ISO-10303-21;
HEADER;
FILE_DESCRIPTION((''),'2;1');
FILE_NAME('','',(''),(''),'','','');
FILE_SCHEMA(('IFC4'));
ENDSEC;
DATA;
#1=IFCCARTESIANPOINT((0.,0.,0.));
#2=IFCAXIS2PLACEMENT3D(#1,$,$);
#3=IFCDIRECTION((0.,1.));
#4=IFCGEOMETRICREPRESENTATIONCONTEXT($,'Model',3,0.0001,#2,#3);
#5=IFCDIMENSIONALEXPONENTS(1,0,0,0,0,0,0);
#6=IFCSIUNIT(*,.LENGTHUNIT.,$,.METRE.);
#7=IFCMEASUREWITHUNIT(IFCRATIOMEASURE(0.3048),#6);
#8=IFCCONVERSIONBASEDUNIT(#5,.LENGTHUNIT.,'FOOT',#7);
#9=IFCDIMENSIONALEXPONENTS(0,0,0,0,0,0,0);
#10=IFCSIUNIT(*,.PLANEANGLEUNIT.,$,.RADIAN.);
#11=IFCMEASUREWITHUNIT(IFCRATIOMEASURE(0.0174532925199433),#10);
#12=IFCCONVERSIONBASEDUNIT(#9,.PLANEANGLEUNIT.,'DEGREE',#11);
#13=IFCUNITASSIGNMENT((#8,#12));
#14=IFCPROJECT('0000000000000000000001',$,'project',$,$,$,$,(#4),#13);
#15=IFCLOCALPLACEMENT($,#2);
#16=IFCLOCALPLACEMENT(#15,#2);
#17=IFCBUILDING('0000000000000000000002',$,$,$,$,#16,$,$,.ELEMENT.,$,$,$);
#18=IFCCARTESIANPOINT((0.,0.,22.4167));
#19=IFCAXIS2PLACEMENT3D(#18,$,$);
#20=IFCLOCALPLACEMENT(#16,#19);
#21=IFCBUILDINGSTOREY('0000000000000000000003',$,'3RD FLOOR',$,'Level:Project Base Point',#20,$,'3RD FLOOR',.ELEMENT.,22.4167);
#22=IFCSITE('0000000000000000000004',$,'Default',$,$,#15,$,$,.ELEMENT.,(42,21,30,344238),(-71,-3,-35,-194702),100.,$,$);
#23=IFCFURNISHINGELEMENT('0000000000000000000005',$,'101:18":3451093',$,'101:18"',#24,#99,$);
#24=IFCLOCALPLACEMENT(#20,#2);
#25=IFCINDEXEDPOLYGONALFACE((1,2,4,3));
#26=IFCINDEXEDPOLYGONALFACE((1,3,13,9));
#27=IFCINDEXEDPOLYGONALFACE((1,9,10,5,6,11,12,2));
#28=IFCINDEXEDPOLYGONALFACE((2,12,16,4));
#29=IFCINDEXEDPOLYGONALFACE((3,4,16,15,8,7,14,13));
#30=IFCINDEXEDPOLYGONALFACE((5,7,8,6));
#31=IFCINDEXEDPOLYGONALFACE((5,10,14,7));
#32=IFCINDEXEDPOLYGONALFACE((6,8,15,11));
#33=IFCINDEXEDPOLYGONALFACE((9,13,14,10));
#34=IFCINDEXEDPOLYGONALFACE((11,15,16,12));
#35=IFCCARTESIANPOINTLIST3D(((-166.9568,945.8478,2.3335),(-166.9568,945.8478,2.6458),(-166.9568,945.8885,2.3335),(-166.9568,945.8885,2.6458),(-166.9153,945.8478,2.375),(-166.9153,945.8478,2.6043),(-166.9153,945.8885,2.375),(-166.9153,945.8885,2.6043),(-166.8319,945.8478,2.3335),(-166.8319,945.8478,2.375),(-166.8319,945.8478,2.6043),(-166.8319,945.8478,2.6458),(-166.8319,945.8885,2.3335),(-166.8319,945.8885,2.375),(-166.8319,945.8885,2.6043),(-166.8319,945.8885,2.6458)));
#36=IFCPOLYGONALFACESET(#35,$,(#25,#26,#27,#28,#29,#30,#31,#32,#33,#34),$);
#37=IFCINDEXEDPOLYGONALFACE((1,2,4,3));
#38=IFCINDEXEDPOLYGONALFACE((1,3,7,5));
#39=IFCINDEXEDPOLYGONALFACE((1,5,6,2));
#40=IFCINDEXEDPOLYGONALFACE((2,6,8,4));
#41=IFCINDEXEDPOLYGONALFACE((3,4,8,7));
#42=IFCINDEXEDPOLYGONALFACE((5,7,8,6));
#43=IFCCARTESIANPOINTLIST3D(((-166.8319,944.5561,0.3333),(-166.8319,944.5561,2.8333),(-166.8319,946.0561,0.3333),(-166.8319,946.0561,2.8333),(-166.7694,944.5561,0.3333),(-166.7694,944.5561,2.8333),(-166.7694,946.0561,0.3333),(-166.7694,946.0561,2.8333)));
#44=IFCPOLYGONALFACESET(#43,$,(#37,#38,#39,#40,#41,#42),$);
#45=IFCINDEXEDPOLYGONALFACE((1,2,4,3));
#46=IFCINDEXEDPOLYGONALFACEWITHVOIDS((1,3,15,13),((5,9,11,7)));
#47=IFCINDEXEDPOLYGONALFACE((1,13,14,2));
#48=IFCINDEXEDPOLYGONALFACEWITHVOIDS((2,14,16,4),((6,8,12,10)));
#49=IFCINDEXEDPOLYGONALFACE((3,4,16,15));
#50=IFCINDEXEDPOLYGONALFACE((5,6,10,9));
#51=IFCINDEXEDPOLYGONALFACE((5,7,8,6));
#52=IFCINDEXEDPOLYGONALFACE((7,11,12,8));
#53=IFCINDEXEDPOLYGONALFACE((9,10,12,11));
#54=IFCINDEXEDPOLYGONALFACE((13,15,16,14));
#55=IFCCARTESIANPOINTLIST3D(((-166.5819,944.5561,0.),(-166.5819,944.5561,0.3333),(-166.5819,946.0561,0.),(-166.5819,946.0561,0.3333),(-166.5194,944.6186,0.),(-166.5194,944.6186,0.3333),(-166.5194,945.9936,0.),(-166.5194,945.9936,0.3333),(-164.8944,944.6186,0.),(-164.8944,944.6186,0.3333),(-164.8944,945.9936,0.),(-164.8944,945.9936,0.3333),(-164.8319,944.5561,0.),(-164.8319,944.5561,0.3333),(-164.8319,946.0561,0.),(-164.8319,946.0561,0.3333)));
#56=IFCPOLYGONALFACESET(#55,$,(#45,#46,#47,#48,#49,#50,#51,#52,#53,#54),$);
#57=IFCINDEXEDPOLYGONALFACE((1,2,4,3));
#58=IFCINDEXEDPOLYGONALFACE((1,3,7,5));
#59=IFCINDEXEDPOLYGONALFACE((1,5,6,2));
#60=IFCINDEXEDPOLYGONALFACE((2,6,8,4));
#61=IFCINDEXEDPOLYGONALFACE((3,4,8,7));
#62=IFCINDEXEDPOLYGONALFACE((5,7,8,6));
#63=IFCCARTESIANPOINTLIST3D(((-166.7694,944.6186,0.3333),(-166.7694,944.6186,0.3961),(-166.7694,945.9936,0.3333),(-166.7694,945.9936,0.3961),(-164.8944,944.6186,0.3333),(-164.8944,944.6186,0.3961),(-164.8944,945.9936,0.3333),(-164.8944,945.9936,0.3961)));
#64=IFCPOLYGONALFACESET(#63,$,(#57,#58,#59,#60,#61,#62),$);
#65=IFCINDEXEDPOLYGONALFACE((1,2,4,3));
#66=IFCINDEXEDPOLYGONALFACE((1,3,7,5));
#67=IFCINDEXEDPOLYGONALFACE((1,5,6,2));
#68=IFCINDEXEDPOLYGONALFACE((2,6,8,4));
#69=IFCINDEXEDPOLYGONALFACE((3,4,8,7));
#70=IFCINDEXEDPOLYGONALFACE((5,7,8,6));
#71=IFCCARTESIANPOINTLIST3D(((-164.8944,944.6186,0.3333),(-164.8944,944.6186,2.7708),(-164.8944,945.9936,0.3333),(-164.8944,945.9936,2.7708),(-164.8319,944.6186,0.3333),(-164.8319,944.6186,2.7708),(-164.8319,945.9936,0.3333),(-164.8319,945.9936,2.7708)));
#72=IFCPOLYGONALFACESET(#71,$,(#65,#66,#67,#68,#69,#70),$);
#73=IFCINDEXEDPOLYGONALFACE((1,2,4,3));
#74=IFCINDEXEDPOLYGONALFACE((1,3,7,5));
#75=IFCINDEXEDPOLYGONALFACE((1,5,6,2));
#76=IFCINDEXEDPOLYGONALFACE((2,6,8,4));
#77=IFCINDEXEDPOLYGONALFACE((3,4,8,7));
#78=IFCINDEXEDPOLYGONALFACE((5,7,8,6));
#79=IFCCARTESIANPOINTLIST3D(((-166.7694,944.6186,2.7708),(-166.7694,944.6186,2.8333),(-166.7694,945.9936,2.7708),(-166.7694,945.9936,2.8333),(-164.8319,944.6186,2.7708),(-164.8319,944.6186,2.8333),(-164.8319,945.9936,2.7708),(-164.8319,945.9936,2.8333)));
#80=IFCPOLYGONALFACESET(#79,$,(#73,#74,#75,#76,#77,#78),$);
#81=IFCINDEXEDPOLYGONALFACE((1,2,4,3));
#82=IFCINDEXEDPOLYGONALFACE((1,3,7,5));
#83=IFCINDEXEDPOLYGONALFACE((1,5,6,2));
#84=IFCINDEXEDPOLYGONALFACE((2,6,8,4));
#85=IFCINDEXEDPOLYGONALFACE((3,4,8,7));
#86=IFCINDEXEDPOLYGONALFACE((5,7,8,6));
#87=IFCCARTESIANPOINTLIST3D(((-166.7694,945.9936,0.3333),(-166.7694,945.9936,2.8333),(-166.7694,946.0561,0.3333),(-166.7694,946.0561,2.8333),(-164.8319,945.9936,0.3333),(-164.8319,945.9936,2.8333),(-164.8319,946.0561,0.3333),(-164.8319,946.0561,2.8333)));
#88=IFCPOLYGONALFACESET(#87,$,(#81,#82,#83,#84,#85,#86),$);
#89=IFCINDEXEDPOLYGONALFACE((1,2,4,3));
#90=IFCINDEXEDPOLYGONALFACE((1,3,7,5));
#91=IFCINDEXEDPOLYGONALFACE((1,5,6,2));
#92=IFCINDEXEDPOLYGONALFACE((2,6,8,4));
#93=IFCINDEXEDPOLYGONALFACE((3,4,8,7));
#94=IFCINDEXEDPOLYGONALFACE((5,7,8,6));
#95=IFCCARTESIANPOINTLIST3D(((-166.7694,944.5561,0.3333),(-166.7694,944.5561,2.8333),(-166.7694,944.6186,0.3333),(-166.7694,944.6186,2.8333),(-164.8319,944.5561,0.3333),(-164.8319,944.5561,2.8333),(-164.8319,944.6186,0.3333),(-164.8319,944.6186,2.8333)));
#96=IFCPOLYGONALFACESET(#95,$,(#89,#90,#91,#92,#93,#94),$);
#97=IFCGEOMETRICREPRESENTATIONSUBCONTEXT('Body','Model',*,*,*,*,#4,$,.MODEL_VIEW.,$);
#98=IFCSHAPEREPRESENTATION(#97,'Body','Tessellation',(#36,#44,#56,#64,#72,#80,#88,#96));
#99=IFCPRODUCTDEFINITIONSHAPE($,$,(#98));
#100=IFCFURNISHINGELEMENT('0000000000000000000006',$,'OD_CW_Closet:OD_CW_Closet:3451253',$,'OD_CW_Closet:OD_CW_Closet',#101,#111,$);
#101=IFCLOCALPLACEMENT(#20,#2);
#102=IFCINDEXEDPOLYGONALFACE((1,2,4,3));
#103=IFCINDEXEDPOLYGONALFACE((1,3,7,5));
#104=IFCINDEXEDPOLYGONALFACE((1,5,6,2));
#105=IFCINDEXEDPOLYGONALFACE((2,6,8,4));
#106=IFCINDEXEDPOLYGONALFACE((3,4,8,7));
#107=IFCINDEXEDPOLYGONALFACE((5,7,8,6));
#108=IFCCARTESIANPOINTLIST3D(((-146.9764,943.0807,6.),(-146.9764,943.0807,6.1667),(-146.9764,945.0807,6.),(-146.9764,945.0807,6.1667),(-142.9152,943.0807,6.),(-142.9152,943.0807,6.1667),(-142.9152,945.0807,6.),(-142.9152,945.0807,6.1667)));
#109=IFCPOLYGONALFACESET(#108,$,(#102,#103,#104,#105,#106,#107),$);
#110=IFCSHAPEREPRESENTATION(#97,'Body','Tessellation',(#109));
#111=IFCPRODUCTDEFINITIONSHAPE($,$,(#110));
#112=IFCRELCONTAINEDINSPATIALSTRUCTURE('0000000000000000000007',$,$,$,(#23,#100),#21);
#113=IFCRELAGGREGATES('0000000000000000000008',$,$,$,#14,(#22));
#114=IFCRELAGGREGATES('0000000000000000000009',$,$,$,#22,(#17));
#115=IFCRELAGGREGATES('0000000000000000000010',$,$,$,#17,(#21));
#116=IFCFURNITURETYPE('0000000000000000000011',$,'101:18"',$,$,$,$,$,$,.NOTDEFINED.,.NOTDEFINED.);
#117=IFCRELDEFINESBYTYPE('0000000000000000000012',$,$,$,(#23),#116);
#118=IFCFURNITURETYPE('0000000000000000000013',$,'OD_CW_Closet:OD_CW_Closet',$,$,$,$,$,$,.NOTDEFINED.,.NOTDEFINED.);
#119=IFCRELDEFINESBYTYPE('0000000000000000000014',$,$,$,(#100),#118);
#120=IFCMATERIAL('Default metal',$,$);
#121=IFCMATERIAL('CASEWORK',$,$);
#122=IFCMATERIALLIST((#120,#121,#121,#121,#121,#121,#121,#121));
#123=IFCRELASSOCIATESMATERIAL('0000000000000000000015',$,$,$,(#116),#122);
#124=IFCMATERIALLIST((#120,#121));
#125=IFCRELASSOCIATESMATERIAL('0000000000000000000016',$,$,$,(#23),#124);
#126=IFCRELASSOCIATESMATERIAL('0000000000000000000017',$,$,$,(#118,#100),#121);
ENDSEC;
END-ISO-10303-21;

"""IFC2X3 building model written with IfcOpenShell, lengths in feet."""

from ifc_helpers import new_model, entity, si_unit, converted_unit, direction, frame, frame_2d, origin, origin_2d_with_axis, place, context, subcontext, project, spatial, polyline, rectangle, outline, extrude, source, transform, mapped, material, material_list, type_object, type_shapes, element, save


model = new_model("IFC2X3")

# Units and contexts
model_context = context("Model", 3, precision=0.0001, world=origin(), true_north=direction((0.0, 1.0)))
body_context = subcontext(model_context, "Body", "Model", "MODEL_VIEW")
ifc_project = project(units=[converted_unit("LENGTHUNIT", "FOOT", entity("IfcRatioMeasure", 0.3048), si_unit("LENGTHUNIT", "METRE"), dimensions=[1, 0, 0, 0, 0, 0, 0]), converted_unit("PLANEANGLEUNIT", "DEGREE", entity("IfcRatioMeasure", 0.0174532925199433), si_unit("PLANEANGLEUNIT", "RADIAN"), dimensions=[0, 0, 0, 0, 0, 0, 0])], contexts=[model_context])

# Site, building, storey
site_placement = place(None, origin())
site = spatial("IfcSite", under=ifc_project, at=site_placement, Name="Default", CompositionType="ELEMENT", RefLatitude=(42, 21, 30, 344238), RefLongitude=(-71, -3, -35, -194702), RefElevation=100.0)
building_placement = place(site_placement, origin())
building = spatial("IfcBuilding", under=site, at=building_placement, CompositionType="ELEMENT")
storey_placement = place(building_placement, frame((0.0, 0.0, 22.4167)))
storey = spatial("IfcBuildingStorey", under=building, at=storey_placement, Name="3RD FLOOR", ObjectType="Level:Project Base Point", LongName="3RD FLOOR", CompositionType="ELEMENT", Elevation=22.4167)

# Furnishing elements
ifc_material_1 = material(Name="CASEWORK")
ifc_material_2 = material(Name="Default metal")
ifc_material_list_1 = material_list([ifc_material_2, ifc_material_1])
ifc_material_list_2 = material_list([ifc_material_2, ifc_material_1, ifc_material_1, ifc_material_1, ifc_material_1, ifc_material_1, ifc_material_1, ifc_material_1])
furniture_type_1 = type_object("IfcFurnitureType", Name="101:18\"", material=ifc_material_list_2)
shared_shape_1 = source(origin(), body_context, "Body", "SweptSolid", [
    extrude(outline(polyline([(-0.0521, -0.1146), (-0.0521, -0.1562), (0.0729, -0.1562), (0.0729, 0.1562), (-0.0521, 0.1562), (-0.0521, 0.1146), (0.0313, 0.1146), (0.0313, -0.1146), (-0.0521, -0.1146)])), frame((0.3531, 2.0521, 2.4896), z_axis=(-1.0, 0.0, 0.0), x_axis=(0.0, 1.0, 0.0)), (0.0, 0.0, -1.0), 0.0407),
    extrude(rectangle(XDim=1.5, YDim=0.0625, at=frame_2d((0.0, 0.0), x_axis=(1.0, 0.0))), frame((-0.1885, 1.9688, 0.3333), z_axis=(0.0, 0.0, 1.0), x_axis=(-1.0, 0.0, 0.0)), (0.0, 0.0, 1.0), 2.5),
    extrude(outline(polyline([(-0.875, -0.75), (0.875, -0.75), (0.875, 0.75), (-0.875, 0.75), (-0.875, -0.75)]), holes=[polyline([(-0.8125, -0.6875), (-0.8125, 0.6875), (0.8125, 0.6875), (0.8125, -0.6875), (-0.8125, -0.6875)])]), frame((-0.1885, 0.875, 0.0), z_axis=(0.0, 0.0, 1.0), x_axis=(0.0, -1.0, 0.0)), (0.0, 0.0, 1.0), 0.3333),
    extrude(rectangle(XDim=1.875, YDim=1.375, at=frame_2d((0.0, 0.0), x_axis=(1.0, 0.0))), frame((-0.1885, 1.0, 0.3333), z_axis=(0.0, 0.0, 1.0), x_axis=(0.0, 1.0, 0.0)), (0.0, 0.0, 1.0), 0.0627),
    extrude(rectangle(XDim=1.375, YDim=0.0625, at=origin_2d_with_axis()), frame((-0.1885, 0.0312, 0.3333), z_axis=(0.0, 0.0, 1.0), x_axis=(-1.0, 0.0, 0.0)), (0.0, 0.0, 1.0), 2.4375),
    extrude(rectangle(XDim=1.9375, YDim=1.375, at=origin_2d_with_axis()), frame((-0.1885, 0.9688, 2.7708), z_axis=(0.0, 0.0, 1.0), x_axis=(0.0, 1.0, 0.0)), (0.0, 0.0, 1.0), 0.0625),
    extrude(rectangle(XDim=1.9375, YDim=0.0625, at=frame_2d((0.0, 0.0), x_axis=(1.0, 0.0))), frame((0.5302, 0.9687, 0.3333), z_axis=(0.0, 0.0, 1.0), x_axis=(0.0, -1.0, 0.0)), (0.0, 0.0, 1.0), 2.5),
    extrude(rectangle(XDim=1.9375, YDim=0.0625, at=origin_2d_with_axis()), frame((-0.9073, 0.9687, 0.3333), z_axis=(0.0, 0.0, 1.0), x_axis=(0.0, -1.0, 0.0)), (0.0, 0.0, 1.0), 2.5),
])
type_shapes(furniture_type_1, [shared_shape_1])
furnishing_1_placement = place(storey_placement, frame((-164.8319, 945.4947, 0.0), z_axis=(0.0, 0.0, 1.0), x_axis=(0.0, 1.0, 0.0)))
element("IfcFurnishingElement", 1, at=furnishing_1_placement, inside=storey, type_object=furniture_type_1, material=ifc_material_list_1, Name="101:18\":3451093", ObjectType="101:18\"", context=body_context, shape_type="MappedRepresentation", body=[
    mapped(shared_shape_1, transform((0.0, 0.0, 0.0), scale=1.0)),
])
furniture_type_2 = type_object("IfcFurnitureType", Name="OD_CW_Closet:OD_CW_Closet", material=ifc_material_1)
shared_shape_2 = source(origin(), body_context, "Body", "SweptSolid", [
    extrude(rectangle(XDim=2.0, YDim=4.0612, at=origin_2d_with_axis()), frame((2.0306, 1.0, 0.0), z_axis=(0.0, 0.0, 1.0), x_axis=(0.0, -1.0, 0.0)), (0.0, 0.0, 1.0), 0.1667),
])
type_shapes(furniture_type_2, [shared_shape_2])
furnishing_2_placement = place(storey_placement, frame((-142.9152, 945.0807, 6.0), z_axis=(0.0, 0.0, 1.0), x_axis=(-1.0, 0.0, 0.0)))
element("IfcFurnishingElement", 2, at=furnishing_2_placement, inside=storey, type_object=furniture_type_2, material=ifc_material_1, Name="OD_CW_Closet:OD_CW_Closet:3451253", ObjectType="OD_CW_Closet:OD_CW_Closet", context=body_context, shape_type="MappedRepresentation", body=[
    mapped(shared_shape_2, transform((0.0, 0.0, 0.0), scale=1.0)),
])

save(model, "model.ifc")
